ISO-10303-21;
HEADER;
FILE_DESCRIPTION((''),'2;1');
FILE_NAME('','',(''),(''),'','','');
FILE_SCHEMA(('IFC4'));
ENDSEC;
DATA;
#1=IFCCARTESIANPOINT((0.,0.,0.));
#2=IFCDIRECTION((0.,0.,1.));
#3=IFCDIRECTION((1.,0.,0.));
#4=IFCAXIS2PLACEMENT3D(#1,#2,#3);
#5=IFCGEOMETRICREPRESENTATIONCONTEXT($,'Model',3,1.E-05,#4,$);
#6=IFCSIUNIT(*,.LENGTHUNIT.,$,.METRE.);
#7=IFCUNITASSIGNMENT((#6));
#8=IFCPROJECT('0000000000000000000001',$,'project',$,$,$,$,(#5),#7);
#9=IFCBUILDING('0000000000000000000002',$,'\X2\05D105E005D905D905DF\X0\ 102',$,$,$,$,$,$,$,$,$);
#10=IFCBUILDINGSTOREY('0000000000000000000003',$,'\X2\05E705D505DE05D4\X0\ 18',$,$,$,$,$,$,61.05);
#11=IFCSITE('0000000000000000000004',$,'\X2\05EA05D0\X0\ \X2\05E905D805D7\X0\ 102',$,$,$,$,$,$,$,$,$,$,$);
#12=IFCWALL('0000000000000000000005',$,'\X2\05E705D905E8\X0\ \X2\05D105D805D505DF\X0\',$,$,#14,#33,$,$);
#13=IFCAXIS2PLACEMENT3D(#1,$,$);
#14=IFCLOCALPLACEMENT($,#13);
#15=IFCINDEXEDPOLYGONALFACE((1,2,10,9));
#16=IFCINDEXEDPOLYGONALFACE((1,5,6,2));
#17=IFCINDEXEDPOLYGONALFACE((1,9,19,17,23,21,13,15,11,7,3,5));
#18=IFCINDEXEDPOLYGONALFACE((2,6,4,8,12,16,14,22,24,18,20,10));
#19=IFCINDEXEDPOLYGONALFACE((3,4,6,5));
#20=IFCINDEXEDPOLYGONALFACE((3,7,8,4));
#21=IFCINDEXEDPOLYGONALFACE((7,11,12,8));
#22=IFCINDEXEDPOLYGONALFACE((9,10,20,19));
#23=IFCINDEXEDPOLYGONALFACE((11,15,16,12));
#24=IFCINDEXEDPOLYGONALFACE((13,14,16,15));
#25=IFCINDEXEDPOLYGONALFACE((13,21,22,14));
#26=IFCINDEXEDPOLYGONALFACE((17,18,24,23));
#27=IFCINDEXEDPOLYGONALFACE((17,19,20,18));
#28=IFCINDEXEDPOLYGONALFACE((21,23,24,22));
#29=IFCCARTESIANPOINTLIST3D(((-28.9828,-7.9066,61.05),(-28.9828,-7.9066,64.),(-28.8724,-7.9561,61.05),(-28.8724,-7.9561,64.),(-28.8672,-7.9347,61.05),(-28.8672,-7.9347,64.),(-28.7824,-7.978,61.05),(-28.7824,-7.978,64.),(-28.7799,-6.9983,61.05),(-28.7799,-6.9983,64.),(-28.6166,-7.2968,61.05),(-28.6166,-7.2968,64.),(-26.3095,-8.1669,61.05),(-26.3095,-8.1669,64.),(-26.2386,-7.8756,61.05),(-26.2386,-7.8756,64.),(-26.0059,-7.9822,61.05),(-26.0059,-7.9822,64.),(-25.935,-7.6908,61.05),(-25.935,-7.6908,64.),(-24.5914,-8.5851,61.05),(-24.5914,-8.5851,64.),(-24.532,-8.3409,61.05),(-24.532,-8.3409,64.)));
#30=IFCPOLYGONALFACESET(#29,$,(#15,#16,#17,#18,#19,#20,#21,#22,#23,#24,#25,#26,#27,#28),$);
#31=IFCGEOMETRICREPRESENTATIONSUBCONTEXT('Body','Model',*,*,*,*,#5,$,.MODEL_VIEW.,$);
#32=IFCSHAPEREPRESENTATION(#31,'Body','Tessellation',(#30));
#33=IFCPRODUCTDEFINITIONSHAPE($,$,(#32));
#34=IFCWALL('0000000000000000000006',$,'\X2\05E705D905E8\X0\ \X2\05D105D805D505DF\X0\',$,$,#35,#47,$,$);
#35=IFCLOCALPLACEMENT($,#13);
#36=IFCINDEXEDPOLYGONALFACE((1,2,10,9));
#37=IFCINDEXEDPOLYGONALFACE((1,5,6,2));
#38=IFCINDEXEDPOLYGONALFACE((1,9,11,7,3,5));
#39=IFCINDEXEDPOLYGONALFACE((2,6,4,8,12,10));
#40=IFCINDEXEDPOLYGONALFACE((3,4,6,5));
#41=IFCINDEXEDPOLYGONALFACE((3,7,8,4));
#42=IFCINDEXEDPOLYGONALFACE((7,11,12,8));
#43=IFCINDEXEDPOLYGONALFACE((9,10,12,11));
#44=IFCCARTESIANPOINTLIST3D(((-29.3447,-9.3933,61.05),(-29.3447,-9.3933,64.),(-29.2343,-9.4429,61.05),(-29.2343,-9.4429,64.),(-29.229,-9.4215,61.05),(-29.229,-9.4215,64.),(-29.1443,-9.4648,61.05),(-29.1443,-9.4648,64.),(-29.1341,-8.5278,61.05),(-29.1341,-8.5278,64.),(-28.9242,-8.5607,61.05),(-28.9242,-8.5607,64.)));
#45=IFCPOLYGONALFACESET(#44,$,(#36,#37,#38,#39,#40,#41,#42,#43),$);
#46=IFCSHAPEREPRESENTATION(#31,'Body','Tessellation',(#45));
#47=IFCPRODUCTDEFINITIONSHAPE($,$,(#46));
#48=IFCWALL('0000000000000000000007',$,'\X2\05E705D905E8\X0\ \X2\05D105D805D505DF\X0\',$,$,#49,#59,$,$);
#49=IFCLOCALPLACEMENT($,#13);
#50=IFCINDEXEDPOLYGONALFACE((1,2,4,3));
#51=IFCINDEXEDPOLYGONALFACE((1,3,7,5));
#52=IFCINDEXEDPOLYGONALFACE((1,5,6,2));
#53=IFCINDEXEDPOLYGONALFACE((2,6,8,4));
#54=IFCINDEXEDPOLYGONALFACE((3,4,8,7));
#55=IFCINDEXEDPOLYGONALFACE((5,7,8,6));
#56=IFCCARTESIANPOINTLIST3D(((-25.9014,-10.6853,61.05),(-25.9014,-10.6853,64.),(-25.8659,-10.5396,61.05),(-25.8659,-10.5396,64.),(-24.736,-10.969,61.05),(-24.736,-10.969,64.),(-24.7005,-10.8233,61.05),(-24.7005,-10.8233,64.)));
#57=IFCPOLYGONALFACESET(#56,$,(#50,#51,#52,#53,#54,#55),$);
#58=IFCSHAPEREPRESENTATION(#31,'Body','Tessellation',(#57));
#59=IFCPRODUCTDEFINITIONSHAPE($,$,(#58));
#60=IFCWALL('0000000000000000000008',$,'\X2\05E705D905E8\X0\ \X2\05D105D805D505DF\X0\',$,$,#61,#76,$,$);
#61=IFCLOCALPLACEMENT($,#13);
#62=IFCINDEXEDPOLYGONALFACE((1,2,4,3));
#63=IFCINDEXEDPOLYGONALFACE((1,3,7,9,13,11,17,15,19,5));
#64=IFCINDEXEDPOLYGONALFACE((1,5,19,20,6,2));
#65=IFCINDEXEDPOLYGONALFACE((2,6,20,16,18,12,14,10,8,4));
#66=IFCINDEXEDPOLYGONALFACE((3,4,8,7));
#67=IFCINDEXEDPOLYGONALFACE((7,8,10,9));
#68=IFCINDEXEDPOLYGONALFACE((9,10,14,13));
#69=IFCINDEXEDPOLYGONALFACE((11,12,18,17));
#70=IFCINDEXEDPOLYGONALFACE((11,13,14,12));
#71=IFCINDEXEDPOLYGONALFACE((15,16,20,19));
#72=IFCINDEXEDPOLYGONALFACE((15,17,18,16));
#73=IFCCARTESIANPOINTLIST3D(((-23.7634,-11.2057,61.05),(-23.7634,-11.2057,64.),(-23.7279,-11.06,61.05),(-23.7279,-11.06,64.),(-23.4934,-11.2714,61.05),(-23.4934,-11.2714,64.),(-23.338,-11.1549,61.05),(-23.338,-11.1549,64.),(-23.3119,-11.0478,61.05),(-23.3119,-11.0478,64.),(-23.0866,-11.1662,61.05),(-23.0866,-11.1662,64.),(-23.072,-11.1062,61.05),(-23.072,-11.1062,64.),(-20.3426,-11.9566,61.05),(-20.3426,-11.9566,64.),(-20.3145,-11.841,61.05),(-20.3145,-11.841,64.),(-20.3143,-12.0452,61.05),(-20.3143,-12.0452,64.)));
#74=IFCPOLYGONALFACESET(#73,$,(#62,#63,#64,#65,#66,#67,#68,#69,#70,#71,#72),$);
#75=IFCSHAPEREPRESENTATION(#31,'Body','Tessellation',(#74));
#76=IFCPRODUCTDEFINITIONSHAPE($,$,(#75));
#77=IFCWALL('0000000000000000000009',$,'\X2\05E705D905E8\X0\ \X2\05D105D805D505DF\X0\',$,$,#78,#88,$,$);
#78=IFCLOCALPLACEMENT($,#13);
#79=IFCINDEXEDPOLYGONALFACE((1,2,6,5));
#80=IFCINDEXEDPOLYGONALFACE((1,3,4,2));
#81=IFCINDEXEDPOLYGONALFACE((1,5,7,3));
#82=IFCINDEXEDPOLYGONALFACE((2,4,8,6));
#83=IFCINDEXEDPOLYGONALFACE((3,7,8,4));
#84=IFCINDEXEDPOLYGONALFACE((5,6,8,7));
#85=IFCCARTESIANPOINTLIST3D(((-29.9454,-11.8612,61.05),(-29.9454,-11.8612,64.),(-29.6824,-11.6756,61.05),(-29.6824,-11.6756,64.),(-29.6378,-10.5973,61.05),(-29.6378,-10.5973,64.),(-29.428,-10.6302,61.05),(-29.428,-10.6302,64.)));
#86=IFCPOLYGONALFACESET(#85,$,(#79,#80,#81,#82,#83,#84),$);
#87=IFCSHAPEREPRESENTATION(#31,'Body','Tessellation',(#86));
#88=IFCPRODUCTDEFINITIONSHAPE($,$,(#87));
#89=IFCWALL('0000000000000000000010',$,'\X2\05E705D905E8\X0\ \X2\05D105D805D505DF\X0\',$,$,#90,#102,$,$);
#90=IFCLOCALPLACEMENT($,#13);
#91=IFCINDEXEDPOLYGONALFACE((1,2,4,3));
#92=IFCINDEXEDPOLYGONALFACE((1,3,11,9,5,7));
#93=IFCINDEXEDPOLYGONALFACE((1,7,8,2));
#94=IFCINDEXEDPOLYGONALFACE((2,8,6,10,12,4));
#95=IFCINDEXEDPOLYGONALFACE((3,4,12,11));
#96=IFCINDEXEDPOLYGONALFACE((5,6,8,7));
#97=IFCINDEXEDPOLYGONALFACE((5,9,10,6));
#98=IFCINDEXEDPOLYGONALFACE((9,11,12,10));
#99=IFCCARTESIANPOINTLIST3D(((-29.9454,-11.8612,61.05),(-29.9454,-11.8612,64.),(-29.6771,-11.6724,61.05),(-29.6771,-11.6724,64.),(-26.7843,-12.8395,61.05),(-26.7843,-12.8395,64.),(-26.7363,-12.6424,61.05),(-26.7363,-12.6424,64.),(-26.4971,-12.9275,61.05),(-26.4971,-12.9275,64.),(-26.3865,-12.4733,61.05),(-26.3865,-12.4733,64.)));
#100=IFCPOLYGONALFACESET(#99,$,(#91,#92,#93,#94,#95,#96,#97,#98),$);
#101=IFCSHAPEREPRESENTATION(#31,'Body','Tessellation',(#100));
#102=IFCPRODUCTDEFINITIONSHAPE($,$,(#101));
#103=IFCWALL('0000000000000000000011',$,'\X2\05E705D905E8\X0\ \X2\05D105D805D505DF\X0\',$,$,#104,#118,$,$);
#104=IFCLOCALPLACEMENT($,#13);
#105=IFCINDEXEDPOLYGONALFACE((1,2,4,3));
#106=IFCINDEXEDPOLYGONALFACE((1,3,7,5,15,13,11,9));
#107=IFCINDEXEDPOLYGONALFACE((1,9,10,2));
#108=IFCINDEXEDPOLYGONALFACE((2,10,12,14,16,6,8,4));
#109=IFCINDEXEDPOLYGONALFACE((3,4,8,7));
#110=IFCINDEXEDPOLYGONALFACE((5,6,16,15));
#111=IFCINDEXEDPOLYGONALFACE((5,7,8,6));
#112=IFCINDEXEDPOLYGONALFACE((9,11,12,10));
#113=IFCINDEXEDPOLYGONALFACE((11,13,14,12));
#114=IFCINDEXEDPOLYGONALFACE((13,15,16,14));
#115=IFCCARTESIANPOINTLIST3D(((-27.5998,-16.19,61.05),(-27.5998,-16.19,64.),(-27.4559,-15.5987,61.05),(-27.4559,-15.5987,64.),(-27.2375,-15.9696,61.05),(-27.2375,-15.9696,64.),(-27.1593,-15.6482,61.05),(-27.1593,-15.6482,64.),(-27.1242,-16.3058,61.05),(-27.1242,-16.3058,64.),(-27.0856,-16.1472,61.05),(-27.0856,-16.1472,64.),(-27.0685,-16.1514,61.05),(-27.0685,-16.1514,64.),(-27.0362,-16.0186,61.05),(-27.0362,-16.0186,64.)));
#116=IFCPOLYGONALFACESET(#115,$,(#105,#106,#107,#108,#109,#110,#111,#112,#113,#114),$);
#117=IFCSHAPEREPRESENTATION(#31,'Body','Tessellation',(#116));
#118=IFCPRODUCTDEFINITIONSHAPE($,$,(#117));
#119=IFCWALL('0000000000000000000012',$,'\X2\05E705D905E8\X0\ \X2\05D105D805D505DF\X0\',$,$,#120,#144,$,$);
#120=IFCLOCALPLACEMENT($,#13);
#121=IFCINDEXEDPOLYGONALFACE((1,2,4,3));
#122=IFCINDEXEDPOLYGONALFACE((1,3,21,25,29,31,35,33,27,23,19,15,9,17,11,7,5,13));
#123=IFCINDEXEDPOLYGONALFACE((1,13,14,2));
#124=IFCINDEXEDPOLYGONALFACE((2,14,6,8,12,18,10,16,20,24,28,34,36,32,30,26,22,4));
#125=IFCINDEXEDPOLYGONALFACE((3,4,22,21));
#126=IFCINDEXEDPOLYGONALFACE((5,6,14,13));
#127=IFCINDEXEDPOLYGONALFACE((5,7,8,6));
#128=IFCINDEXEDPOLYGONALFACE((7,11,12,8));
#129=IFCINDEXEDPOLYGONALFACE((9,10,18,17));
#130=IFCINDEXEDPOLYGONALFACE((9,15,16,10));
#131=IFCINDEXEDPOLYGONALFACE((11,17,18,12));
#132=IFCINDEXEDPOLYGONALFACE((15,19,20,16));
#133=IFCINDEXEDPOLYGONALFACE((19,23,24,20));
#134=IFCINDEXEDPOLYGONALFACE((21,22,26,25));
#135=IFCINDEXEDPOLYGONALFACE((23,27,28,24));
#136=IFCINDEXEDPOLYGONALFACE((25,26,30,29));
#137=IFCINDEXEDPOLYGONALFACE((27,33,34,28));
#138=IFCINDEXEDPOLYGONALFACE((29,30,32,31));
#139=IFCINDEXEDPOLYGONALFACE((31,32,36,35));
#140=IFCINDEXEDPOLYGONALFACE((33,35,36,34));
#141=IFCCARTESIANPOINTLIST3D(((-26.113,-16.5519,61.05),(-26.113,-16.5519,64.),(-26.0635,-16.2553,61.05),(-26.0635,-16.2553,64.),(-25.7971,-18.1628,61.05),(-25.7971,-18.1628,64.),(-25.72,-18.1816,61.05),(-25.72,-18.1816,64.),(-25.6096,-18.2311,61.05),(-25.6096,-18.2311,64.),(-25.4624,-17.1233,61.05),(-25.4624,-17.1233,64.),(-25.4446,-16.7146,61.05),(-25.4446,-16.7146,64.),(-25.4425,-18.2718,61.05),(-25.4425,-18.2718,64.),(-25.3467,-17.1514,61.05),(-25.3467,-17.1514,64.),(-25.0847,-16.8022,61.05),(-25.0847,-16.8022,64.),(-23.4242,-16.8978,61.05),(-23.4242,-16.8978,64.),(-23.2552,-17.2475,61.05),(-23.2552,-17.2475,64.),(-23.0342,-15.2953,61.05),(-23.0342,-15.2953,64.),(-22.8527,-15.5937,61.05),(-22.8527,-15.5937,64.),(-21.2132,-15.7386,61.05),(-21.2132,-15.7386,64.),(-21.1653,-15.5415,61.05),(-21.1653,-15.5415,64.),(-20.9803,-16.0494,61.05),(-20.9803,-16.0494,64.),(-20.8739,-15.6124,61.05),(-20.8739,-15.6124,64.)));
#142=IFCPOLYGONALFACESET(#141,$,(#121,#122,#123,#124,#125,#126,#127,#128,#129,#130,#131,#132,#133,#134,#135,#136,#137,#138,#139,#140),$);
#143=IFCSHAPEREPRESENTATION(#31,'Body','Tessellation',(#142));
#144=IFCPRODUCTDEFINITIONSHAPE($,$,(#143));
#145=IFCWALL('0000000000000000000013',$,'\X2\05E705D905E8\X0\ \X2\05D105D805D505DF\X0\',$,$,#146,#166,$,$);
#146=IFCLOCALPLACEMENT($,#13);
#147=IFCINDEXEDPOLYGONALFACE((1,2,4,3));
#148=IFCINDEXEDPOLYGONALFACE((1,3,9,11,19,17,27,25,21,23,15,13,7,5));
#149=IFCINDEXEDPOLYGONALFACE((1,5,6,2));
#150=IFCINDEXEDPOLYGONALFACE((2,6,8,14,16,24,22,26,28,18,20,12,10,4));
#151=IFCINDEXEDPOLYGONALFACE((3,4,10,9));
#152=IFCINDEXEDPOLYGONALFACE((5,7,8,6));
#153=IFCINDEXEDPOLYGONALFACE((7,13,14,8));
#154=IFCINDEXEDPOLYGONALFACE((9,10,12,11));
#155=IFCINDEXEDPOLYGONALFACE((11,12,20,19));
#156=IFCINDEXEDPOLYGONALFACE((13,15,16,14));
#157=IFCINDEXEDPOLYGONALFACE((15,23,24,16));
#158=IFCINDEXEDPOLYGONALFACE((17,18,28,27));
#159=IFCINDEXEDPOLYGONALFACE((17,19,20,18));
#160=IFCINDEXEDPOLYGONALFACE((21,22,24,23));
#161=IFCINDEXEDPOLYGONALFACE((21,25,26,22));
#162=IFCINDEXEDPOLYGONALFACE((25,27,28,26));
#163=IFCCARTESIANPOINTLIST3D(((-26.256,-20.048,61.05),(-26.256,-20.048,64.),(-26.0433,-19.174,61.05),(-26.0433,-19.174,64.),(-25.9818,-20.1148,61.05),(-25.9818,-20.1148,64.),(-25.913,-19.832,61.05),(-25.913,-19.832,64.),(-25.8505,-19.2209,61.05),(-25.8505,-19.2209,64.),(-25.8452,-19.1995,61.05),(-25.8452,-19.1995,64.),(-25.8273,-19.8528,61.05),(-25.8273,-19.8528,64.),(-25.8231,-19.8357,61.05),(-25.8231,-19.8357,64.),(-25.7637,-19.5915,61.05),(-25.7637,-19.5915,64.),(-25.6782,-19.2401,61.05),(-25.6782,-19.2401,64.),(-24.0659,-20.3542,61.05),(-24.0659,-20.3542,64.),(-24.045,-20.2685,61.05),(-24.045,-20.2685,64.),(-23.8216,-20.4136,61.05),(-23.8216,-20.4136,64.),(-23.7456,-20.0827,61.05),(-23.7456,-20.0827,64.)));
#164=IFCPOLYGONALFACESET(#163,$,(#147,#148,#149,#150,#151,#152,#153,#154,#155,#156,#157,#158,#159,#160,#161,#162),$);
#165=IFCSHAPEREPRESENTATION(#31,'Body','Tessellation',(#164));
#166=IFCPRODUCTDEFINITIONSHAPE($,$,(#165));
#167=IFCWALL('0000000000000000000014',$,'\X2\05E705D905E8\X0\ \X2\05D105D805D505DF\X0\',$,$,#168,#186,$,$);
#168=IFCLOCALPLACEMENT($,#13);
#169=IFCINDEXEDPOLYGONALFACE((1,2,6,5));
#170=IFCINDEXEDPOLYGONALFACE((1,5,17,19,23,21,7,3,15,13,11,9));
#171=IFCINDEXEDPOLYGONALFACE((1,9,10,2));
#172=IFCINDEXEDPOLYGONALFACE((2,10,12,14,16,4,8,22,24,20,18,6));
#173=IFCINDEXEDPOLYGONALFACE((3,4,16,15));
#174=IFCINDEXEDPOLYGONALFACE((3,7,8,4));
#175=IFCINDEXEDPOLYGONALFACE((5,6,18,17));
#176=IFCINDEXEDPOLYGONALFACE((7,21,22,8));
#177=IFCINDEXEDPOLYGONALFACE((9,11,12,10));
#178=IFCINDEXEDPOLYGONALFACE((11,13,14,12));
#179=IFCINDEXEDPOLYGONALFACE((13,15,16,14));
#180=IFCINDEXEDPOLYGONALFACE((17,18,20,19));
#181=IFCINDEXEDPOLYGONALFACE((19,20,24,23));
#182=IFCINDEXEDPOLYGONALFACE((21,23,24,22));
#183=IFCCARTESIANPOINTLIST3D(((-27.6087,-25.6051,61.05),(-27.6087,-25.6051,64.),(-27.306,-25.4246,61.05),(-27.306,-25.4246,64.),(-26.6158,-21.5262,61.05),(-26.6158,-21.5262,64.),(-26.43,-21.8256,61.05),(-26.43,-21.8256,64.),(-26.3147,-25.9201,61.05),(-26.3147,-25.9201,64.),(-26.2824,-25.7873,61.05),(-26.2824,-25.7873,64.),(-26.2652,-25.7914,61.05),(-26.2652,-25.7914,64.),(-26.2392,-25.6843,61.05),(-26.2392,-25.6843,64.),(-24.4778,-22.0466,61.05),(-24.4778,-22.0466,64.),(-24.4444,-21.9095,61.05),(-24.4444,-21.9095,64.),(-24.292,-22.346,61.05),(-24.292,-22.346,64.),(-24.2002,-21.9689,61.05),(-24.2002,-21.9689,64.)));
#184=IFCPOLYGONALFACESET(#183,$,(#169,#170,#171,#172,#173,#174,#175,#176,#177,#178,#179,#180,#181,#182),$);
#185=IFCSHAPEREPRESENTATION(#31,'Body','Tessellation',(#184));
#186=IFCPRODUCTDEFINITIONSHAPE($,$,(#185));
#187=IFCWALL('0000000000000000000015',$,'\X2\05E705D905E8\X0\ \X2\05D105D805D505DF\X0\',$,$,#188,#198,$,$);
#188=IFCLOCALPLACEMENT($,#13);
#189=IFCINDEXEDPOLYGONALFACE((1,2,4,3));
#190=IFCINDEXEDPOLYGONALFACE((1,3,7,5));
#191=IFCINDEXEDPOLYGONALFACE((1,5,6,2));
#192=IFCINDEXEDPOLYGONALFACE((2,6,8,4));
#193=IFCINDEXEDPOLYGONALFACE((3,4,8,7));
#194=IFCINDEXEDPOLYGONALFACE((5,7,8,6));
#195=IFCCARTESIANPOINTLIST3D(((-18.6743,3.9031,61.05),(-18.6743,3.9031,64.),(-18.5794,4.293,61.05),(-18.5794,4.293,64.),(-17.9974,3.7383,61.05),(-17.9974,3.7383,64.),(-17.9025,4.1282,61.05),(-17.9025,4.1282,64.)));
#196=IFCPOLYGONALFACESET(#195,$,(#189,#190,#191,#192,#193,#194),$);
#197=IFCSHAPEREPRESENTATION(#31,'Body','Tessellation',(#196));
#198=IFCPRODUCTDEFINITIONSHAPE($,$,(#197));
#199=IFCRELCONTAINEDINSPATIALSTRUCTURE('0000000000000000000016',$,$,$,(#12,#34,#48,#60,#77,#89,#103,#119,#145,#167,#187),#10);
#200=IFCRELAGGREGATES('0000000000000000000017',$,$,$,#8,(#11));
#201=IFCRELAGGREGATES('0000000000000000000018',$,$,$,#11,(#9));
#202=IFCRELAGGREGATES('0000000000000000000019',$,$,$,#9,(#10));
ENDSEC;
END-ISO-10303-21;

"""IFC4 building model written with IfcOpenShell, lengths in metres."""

from ifc_helpers import new_model, si_unit, frame, origin_with_axes, context, subcontext, project, spatial, polyline, outline, extrude, element, save


model = new_model("IFC4")

# Units and contexts
model_context = context("Model", 3, precision=1e-05, world=origin_with_axes())
body_context = subcontext(model_context, "Body", "Model", "MODEL_VIEW")
ifc_project = project(units=[si_unit("LENGTHUNIT", "METRE")], contexts=[model_context])

# Site, building, storey
site = spatial("IfcSite", under=ifc_project, Name="תא שטח 102")
building = spatial("IfcBuilding", under=site, Name="בניין 102")
storey = spatial("IfcBuildingStorey", under=building, Name="קומה 18", Elevation=61.05)

# Walls
element("IfcWall", 1, inside=storey, Name="קיר בטון", context=body_context, shape_type="SweptSolid", body=[
    extrude(outline(polyline([(-28.8672, -7.9347), (-28.8724, -7.9561), (-28.7824, -7.978), (-28.6166, -7.2968), (-26.2386, -7.8756), (-26.3095, -8.1669), (-24.5914, -8.5851), (-24.532, -8.3409), (-26.0059, -7.9822), (-25.935, -7.6908), (-28.7799, -6.9983), (-28.9828, -7.9066), (-28.8672, -7.9347)])), frame((0.0, 0.0, 61.05)), (0.0, 0.0, 1.0), 2.95),
])
element("IfcWall", 2, inside=storey, Name="קיר בטון", context=body_context, shape_type="SweptSolid", body=[
    extrude(outline(polyline([(-29.229, -9.4215), (-29.2343, -9.4429), (-29.1443, -9.4648), (-28.9242, -8.5607), (-29.1341, -8.5278), (-29.3447, -9.3933), (-29.229, -9.4215)])), frame((0.0, 0.0, 61.05)), (0.0, 0.0, 1.0), 2.95),
])
element("IfcWall", 3, inside=storey, Name="קיר בטון", context=body_context, shape_type="SweptSolid", body=[
    extrude(outline(polyline([(-25.8659, -10.5396), (-25.9014, -10.6853), (-24.736, -10.969), (-24.7005, -10.8233), (-25.8659, -10.5396)])), frame((0.0, 0.0, 61.05)), (0.0, 0.0, 1.0), 2.95),
])
element("IfcWall", 4, inside=storey, Name="קיר בטון", context=body_context, shape_type="SweptSolid", body=[
    extrude(outline(polyline([(-23.7634, -11.2057), (-23.4934, -11.2714), (-20.3143, -12.0452), (-20.3426, -11.9566), (-20.3145, -11.841), (-23.0866, -11.1662), (-23.072, -11.1062), (-23.3119, -11.0478), (-23.338, -11.1549), (-23.7279, -11.06), (-23.7634, -11.2057)])), frame((0.0, 0.0, 61.05)), (0.0, 0.0, 1.0), 2.95),
])
element("IfcWall", 5, inside=storey, Name="קיר בטון", context=body_context, shape_type="SweptSolid", body=[
    extrude(outline(polyline([(-29.9454, -11.8612), (-29.6824, -11.6756), (-29.428, -10.6302), (-29.6378, -10.5973), (-29.9454, -11.8612)])), frame((0.0, 0.0, 61.05)), (0.0, 0.0, 1.0), 2.95),
])
element("IfcWall", 6, inside=storey, Name="קיר בטון", context=body_context, shape_type="SweptSolid", body=[
    extrude(outline(polyline([(-26.7843, -12.8395), (-26.4971, -12.9275), (-26.3865, -12.4733), (-29.6771, -11.6724), (-29.9454, -11.8612), (-26.7363, -12.6424), (-26.7843, -12.8395)])), frame((0.0, 0.0, 61.05)), (0.0, 0.0, 1.0), 2.95),
])
element("IfcWall", 7, inside=storey, Name="קיר בטון", context=body_context, shape_type="SweptSolid", body=[
    extrude(outline(polyline([(-27.0856, -16.1472), (-27.0685, -16.1514), (-27.0362, -16.0186), (-27.2375, -15.9696), (-27.1593, -15.6482), (-27.4559, -15.5987), (-27.5998, -16.19), (-27.1242, -16.3058), (-27.0856, -16.1472)])), frame((0.0, 0.0, 61.05)), (0.0, 0.0, 1.0), 2.95),
])
element("IfcWall", 8, inside=storey, Name="קיר בטון", context=body_context, shape_type="SweptSolid", body=[
    extrude(outline(polyline([(-25.6096, -18.2311), (-25.4425, -18.2718), (-25.0847, -16.8022), (-23.2552, -17.2475), (-22.8527, -15.5937), (-20.9803, -16.0494), (-20.8739, -15.6124), (-21.1653, -15.5415), (-21.2132, -15.7386), (-23.0342, -15.2953), (-23.4242, -16.8978), (-26.0635, -16.2553), (-26.113, -16.5519), (-25.4446, -16.7146), (-25.7971, -18.1628), (-25.72, -18.1816), (-25.4624, -17.1233), (-25.3467, -17.1514), (-25.6096, -18.2311)])), frame((0.0, 0.0, 61.05)), (0.0, 0.0, 1.0), 2.95),
])
element("IfcWall", 9, inside=storey, Name="קיר בטון", context=body_context, shape_type="SweptSolid", body=[
    extrude(outline(polyline([(-25.8505, -19.2209), (-26.0433, -19.174), (-26.256, -20.048), (-25.9818, -20.1148), (-25.913, -19.832), (-25.8273, -19.8528), (-25.8231, -19.8357), (-24.045, -20.2685), (-24.0659, -20.3542), (-23.8216, -20.4136), (-23.7456, -20.0827), (-25.7637, -19.5915), (-25.6782, -19.2401), (-25.8452, -19.1995), (-25.8505, -19.2209)])), frame((0.0, 0.0, 61.05)), (0.0, 0.0, 1.0), 2.95),
])
element("IfcWall", 10, inside=storey, Name="קיר בטון", context=body_context, shape_type="SweptSolid", body=[
    extrude(outline(polyline([(-27.6087, -25.6051), (-26.3147, -25.9201), (-26.2824, -25.7873), (-26.2652, -25.7914), (-26.2392, -25.6843), (-27.306, -25.4246), (-26.43, -21.8256), (-24.292, -22.346), (-24.2002, -21.9689), (-24.4444, -21.9095), (-24.4778, -22.0466), (-26.6158, -21.5262), (-27.6087, -25.6051)])), frame((0.0, 0.0, 61.05)), (0.0, 0.0, 1.0), 2.95),
])
element("IfcWall", 11, inside=storey, Name="קיר בטון", context=body_context, shape_type="SweptSolid", body=[
    extrude(outline(polyline([(-17.9974, 3.7383), (-17.9025, 4.1282), (-18.5794, 4.293), (-18.6743, 3.9031), (-17.9974, 3.7383)])), frame((0.0, 0.0, 61.05)), (0.0, 0.0, 1.0), 2.95),
])

save(model, "model.ifc")
